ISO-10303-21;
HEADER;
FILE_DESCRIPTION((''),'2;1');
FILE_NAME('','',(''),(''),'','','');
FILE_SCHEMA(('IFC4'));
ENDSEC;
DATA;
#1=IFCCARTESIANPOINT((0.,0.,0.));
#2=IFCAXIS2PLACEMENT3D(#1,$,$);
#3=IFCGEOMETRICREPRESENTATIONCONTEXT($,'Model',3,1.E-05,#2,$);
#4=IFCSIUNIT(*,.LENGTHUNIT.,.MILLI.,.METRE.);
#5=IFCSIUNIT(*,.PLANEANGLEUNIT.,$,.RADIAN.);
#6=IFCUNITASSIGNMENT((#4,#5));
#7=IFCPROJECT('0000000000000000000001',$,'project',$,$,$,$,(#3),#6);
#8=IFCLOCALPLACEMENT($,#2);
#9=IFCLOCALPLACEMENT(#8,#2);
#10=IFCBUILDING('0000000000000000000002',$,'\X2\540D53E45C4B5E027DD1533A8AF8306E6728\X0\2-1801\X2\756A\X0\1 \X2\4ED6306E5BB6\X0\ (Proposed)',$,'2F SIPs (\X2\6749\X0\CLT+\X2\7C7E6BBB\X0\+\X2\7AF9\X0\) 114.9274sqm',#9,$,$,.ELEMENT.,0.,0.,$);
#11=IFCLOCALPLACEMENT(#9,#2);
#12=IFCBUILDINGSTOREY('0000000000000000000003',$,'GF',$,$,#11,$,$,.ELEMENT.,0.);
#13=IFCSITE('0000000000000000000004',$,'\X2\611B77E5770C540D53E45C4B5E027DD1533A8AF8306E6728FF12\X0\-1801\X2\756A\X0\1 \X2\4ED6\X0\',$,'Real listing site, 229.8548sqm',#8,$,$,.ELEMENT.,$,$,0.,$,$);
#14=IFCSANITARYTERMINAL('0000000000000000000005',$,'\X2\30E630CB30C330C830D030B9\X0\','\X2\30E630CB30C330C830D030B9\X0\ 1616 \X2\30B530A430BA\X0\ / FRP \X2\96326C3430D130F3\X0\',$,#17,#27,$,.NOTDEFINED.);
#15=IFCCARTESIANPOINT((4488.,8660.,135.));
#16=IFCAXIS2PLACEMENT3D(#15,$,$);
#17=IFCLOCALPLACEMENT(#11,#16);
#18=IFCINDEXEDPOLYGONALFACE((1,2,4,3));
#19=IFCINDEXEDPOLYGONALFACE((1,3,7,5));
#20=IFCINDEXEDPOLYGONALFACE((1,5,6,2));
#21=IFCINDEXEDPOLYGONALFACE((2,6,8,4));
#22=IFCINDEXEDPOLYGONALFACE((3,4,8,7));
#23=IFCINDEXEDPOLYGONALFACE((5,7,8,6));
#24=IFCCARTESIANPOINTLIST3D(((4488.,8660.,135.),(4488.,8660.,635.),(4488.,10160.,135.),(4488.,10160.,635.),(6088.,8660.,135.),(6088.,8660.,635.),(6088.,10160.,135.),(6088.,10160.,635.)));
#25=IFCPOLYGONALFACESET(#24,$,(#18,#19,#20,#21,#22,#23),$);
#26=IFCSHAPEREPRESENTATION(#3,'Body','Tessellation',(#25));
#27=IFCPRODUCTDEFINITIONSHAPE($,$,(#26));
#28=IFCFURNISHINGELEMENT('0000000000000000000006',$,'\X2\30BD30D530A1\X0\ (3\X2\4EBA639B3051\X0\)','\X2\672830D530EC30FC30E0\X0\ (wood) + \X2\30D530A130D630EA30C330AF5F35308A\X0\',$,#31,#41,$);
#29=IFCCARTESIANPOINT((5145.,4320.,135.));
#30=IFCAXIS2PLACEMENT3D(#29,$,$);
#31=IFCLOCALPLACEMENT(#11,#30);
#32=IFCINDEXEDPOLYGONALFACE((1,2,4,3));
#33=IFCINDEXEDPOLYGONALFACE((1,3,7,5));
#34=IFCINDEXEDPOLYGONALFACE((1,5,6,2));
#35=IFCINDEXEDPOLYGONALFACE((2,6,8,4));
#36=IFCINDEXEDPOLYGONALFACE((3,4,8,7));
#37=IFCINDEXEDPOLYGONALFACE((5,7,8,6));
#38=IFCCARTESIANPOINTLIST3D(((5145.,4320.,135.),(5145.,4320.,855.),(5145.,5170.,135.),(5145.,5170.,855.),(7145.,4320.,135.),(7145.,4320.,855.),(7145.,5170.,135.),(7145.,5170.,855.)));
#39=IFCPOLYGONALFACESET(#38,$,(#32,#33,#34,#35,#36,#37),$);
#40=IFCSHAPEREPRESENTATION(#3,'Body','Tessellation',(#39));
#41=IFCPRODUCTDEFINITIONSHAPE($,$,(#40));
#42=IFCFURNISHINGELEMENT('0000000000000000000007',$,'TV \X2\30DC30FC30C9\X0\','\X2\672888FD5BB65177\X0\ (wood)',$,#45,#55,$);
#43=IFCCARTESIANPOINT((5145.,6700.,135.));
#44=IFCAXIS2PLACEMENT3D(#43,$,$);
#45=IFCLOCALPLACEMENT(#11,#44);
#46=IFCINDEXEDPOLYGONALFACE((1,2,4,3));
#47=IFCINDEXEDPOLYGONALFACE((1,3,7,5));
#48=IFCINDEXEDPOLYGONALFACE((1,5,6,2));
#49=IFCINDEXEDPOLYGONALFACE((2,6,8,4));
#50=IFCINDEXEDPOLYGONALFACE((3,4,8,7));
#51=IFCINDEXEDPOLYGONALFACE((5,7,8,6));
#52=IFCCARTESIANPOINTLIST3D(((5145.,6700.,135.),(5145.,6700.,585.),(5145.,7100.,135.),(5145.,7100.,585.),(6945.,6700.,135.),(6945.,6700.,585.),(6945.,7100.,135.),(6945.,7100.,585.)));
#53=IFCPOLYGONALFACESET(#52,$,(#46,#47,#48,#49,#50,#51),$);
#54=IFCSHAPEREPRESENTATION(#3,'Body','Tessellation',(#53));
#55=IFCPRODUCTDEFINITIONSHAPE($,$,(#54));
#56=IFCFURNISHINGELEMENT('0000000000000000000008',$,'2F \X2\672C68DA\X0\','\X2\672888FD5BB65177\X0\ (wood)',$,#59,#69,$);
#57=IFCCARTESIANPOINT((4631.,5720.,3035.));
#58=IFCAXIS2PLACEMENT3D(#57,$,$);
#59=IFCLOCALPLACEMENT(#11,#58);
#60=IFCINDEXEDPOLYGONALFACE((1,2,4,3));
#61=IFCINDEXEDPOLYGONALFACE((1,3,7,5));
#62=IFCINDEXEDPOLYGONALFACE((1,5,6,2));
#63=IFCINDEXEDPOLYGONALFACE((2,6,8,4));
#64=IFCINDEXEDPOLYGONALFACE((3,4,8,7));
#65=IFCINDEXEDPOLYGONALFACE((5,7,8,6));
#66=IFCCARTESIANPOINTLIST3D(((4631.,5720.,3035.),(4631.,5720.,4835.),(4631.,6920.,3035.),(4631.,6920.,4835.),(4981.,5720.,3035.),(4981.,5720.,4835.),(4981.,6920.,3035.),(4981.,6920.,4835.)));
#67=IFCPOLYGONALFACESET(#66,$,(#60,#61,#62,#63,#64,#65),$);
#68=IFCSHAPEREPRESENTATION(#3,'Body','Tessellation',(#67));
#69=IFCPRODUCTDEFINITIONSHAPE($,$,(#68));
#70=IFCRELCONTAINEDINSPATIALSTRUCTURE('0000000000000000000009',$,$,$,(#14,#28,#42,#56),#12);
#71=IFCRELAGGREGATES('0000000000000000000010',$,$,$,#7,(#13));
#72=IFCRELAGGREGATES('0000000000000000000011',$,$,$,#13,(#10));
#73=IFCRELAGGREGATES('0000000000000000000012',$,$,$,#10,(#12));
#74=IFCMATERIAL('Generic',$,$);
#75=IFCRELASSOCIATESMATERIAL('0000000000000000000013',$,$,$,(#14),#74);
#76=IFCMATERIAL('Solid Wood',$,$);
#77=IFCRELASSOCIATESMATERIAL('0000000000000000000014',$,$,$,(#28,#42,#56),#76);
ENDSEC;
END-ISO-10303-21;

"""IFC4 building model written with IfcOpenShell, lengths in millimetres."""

from ifc_helpers import new_model, si_unit, frame, frame_2d, origin, place, context, project, spatial, rectangle, extrude, material, element, save


model = new_model("IFC4")

# Units and contexts
model_context = context("Model", 3, precision=1e-05, world=origin())
ifc_project = project(units=[si_unit("LENGTHUNIT", "METRE", prefix="MILLI"), si_unit("PLANEANGLEUNIT", "RADIAN")], contexts=[model_context])

# Site, building, storey
site_placement = place(None, origin())
site = spatial("IfcSite", under=ifc_project, at=site_placement, Name="愛知県名古屋市緑区諸の木２-1801番1 他", ObjectType="Real listing site, 229.8548sqm", CompositionType="ELEMENT", RefElevation=0.0)
building_placement = place(site_placement, origin())
building = spatial("IfcBuilding", under=site, at=building_placement, Name="名古屋市緑区諸の木2-1801番1 他の家 (Proposed)", ObjectType="2F SIPs (杉CLT+籾殻+竹) 114.9274sqm", CompositionType="ELEMENT", ElevationOfRefHeight=0.0, ElevationOfTerrain=0.0)
storey_placement = place(building_placement, origin())
storey = spatial("IfcBuildingStorey", under=building, at=storey_placement, Name="GF", CompositionType="ELEMENT", Elevation=0.0)

# Shared definitions
ifc_material_1 = material(Name="Solid Wood")

# Sanitary terminal
ifc_material_2 = material(Name="Generic")
sanitary_terminal_placement = place(storey_placement, frame((4488.0, 8660.0, 135.0)))
element("IfcSanitaryTerminal", 1, at=sanitary_terminal_placement, inside=storey, material=ifc_material_2, Name="ユニットバス", Description="ユニットバス 1616 サイズ / FRP 防水パン", PredefinedType="NOTDEFINED", context=model_context, shape_type="SweptSolid", body=[
    extrude(rectangle(XDim=1600.0, YDim=1500.0, at=frame_2d((800.0, 750.0))), frame((4488.0, 8660.0, 135.0)), (0.0, 0.0, 1.0), 500.0),
])

# Furnishing elements
furnishing_1_placement = place(storey_placement, frame((5145.0, 4320.0, 135.0)))
element("IfcFurnishingElement", 2, at=furnishing_1_placement, inside=storey, material=ifc_material_1, Name="ソファ (3人掛け)", Description="木フレーム (wood) + ファブリック張り", context=model_context, shape_type="SweptSolid", body=[
    extrude(rectangle(XDim=2000.0, YDim=850.0, at=frame_2d((1000.0, 425.0))), frame((5145.0, 4320.0, 135.0)), (0.0, 0.0, 1.0), 720.0),
])
furnishing_2_placement = place(storey_placement, frame((5145.0, 6700.0, 135.0)))
element("IfcFurnishingElement", 3, at=furnishing_2_placement, inside=storey, material=ifc_material_1, Name="TV ボード", Description="木製家具 (wood)", context=model_context, shape_type="SweptSolid", body=[
    extrude(rectangle(XDim=1800.0, YDim=400.0, at=frame_2d((900.0, 200.0))), frame((5145.0, 6700.0, 135.0)), (0.0, 0.0, 1.0), 450.0),
])
furnishing_3_placement = place(storey_placement, frame((4631.0, 5720.0, 3035.0)))
element("IfcFurnishingElement", 4, at=furnishing_3_placement, inside=storey, material=ifc_material_1, Name="2F 本棚", Description="木製家具 (wood)", context=model_context, shape_type="SweptSolid", body=[
    extrude(rectangle(XDim=350.0, YDim=1200.0, at=frame_2d((175.0, 600.0))), frame((4631.0, 5720.0, 3035.0)), (0.0, 0.0, 1.0), 1800.0),
])

save(model, "model.ifc")
